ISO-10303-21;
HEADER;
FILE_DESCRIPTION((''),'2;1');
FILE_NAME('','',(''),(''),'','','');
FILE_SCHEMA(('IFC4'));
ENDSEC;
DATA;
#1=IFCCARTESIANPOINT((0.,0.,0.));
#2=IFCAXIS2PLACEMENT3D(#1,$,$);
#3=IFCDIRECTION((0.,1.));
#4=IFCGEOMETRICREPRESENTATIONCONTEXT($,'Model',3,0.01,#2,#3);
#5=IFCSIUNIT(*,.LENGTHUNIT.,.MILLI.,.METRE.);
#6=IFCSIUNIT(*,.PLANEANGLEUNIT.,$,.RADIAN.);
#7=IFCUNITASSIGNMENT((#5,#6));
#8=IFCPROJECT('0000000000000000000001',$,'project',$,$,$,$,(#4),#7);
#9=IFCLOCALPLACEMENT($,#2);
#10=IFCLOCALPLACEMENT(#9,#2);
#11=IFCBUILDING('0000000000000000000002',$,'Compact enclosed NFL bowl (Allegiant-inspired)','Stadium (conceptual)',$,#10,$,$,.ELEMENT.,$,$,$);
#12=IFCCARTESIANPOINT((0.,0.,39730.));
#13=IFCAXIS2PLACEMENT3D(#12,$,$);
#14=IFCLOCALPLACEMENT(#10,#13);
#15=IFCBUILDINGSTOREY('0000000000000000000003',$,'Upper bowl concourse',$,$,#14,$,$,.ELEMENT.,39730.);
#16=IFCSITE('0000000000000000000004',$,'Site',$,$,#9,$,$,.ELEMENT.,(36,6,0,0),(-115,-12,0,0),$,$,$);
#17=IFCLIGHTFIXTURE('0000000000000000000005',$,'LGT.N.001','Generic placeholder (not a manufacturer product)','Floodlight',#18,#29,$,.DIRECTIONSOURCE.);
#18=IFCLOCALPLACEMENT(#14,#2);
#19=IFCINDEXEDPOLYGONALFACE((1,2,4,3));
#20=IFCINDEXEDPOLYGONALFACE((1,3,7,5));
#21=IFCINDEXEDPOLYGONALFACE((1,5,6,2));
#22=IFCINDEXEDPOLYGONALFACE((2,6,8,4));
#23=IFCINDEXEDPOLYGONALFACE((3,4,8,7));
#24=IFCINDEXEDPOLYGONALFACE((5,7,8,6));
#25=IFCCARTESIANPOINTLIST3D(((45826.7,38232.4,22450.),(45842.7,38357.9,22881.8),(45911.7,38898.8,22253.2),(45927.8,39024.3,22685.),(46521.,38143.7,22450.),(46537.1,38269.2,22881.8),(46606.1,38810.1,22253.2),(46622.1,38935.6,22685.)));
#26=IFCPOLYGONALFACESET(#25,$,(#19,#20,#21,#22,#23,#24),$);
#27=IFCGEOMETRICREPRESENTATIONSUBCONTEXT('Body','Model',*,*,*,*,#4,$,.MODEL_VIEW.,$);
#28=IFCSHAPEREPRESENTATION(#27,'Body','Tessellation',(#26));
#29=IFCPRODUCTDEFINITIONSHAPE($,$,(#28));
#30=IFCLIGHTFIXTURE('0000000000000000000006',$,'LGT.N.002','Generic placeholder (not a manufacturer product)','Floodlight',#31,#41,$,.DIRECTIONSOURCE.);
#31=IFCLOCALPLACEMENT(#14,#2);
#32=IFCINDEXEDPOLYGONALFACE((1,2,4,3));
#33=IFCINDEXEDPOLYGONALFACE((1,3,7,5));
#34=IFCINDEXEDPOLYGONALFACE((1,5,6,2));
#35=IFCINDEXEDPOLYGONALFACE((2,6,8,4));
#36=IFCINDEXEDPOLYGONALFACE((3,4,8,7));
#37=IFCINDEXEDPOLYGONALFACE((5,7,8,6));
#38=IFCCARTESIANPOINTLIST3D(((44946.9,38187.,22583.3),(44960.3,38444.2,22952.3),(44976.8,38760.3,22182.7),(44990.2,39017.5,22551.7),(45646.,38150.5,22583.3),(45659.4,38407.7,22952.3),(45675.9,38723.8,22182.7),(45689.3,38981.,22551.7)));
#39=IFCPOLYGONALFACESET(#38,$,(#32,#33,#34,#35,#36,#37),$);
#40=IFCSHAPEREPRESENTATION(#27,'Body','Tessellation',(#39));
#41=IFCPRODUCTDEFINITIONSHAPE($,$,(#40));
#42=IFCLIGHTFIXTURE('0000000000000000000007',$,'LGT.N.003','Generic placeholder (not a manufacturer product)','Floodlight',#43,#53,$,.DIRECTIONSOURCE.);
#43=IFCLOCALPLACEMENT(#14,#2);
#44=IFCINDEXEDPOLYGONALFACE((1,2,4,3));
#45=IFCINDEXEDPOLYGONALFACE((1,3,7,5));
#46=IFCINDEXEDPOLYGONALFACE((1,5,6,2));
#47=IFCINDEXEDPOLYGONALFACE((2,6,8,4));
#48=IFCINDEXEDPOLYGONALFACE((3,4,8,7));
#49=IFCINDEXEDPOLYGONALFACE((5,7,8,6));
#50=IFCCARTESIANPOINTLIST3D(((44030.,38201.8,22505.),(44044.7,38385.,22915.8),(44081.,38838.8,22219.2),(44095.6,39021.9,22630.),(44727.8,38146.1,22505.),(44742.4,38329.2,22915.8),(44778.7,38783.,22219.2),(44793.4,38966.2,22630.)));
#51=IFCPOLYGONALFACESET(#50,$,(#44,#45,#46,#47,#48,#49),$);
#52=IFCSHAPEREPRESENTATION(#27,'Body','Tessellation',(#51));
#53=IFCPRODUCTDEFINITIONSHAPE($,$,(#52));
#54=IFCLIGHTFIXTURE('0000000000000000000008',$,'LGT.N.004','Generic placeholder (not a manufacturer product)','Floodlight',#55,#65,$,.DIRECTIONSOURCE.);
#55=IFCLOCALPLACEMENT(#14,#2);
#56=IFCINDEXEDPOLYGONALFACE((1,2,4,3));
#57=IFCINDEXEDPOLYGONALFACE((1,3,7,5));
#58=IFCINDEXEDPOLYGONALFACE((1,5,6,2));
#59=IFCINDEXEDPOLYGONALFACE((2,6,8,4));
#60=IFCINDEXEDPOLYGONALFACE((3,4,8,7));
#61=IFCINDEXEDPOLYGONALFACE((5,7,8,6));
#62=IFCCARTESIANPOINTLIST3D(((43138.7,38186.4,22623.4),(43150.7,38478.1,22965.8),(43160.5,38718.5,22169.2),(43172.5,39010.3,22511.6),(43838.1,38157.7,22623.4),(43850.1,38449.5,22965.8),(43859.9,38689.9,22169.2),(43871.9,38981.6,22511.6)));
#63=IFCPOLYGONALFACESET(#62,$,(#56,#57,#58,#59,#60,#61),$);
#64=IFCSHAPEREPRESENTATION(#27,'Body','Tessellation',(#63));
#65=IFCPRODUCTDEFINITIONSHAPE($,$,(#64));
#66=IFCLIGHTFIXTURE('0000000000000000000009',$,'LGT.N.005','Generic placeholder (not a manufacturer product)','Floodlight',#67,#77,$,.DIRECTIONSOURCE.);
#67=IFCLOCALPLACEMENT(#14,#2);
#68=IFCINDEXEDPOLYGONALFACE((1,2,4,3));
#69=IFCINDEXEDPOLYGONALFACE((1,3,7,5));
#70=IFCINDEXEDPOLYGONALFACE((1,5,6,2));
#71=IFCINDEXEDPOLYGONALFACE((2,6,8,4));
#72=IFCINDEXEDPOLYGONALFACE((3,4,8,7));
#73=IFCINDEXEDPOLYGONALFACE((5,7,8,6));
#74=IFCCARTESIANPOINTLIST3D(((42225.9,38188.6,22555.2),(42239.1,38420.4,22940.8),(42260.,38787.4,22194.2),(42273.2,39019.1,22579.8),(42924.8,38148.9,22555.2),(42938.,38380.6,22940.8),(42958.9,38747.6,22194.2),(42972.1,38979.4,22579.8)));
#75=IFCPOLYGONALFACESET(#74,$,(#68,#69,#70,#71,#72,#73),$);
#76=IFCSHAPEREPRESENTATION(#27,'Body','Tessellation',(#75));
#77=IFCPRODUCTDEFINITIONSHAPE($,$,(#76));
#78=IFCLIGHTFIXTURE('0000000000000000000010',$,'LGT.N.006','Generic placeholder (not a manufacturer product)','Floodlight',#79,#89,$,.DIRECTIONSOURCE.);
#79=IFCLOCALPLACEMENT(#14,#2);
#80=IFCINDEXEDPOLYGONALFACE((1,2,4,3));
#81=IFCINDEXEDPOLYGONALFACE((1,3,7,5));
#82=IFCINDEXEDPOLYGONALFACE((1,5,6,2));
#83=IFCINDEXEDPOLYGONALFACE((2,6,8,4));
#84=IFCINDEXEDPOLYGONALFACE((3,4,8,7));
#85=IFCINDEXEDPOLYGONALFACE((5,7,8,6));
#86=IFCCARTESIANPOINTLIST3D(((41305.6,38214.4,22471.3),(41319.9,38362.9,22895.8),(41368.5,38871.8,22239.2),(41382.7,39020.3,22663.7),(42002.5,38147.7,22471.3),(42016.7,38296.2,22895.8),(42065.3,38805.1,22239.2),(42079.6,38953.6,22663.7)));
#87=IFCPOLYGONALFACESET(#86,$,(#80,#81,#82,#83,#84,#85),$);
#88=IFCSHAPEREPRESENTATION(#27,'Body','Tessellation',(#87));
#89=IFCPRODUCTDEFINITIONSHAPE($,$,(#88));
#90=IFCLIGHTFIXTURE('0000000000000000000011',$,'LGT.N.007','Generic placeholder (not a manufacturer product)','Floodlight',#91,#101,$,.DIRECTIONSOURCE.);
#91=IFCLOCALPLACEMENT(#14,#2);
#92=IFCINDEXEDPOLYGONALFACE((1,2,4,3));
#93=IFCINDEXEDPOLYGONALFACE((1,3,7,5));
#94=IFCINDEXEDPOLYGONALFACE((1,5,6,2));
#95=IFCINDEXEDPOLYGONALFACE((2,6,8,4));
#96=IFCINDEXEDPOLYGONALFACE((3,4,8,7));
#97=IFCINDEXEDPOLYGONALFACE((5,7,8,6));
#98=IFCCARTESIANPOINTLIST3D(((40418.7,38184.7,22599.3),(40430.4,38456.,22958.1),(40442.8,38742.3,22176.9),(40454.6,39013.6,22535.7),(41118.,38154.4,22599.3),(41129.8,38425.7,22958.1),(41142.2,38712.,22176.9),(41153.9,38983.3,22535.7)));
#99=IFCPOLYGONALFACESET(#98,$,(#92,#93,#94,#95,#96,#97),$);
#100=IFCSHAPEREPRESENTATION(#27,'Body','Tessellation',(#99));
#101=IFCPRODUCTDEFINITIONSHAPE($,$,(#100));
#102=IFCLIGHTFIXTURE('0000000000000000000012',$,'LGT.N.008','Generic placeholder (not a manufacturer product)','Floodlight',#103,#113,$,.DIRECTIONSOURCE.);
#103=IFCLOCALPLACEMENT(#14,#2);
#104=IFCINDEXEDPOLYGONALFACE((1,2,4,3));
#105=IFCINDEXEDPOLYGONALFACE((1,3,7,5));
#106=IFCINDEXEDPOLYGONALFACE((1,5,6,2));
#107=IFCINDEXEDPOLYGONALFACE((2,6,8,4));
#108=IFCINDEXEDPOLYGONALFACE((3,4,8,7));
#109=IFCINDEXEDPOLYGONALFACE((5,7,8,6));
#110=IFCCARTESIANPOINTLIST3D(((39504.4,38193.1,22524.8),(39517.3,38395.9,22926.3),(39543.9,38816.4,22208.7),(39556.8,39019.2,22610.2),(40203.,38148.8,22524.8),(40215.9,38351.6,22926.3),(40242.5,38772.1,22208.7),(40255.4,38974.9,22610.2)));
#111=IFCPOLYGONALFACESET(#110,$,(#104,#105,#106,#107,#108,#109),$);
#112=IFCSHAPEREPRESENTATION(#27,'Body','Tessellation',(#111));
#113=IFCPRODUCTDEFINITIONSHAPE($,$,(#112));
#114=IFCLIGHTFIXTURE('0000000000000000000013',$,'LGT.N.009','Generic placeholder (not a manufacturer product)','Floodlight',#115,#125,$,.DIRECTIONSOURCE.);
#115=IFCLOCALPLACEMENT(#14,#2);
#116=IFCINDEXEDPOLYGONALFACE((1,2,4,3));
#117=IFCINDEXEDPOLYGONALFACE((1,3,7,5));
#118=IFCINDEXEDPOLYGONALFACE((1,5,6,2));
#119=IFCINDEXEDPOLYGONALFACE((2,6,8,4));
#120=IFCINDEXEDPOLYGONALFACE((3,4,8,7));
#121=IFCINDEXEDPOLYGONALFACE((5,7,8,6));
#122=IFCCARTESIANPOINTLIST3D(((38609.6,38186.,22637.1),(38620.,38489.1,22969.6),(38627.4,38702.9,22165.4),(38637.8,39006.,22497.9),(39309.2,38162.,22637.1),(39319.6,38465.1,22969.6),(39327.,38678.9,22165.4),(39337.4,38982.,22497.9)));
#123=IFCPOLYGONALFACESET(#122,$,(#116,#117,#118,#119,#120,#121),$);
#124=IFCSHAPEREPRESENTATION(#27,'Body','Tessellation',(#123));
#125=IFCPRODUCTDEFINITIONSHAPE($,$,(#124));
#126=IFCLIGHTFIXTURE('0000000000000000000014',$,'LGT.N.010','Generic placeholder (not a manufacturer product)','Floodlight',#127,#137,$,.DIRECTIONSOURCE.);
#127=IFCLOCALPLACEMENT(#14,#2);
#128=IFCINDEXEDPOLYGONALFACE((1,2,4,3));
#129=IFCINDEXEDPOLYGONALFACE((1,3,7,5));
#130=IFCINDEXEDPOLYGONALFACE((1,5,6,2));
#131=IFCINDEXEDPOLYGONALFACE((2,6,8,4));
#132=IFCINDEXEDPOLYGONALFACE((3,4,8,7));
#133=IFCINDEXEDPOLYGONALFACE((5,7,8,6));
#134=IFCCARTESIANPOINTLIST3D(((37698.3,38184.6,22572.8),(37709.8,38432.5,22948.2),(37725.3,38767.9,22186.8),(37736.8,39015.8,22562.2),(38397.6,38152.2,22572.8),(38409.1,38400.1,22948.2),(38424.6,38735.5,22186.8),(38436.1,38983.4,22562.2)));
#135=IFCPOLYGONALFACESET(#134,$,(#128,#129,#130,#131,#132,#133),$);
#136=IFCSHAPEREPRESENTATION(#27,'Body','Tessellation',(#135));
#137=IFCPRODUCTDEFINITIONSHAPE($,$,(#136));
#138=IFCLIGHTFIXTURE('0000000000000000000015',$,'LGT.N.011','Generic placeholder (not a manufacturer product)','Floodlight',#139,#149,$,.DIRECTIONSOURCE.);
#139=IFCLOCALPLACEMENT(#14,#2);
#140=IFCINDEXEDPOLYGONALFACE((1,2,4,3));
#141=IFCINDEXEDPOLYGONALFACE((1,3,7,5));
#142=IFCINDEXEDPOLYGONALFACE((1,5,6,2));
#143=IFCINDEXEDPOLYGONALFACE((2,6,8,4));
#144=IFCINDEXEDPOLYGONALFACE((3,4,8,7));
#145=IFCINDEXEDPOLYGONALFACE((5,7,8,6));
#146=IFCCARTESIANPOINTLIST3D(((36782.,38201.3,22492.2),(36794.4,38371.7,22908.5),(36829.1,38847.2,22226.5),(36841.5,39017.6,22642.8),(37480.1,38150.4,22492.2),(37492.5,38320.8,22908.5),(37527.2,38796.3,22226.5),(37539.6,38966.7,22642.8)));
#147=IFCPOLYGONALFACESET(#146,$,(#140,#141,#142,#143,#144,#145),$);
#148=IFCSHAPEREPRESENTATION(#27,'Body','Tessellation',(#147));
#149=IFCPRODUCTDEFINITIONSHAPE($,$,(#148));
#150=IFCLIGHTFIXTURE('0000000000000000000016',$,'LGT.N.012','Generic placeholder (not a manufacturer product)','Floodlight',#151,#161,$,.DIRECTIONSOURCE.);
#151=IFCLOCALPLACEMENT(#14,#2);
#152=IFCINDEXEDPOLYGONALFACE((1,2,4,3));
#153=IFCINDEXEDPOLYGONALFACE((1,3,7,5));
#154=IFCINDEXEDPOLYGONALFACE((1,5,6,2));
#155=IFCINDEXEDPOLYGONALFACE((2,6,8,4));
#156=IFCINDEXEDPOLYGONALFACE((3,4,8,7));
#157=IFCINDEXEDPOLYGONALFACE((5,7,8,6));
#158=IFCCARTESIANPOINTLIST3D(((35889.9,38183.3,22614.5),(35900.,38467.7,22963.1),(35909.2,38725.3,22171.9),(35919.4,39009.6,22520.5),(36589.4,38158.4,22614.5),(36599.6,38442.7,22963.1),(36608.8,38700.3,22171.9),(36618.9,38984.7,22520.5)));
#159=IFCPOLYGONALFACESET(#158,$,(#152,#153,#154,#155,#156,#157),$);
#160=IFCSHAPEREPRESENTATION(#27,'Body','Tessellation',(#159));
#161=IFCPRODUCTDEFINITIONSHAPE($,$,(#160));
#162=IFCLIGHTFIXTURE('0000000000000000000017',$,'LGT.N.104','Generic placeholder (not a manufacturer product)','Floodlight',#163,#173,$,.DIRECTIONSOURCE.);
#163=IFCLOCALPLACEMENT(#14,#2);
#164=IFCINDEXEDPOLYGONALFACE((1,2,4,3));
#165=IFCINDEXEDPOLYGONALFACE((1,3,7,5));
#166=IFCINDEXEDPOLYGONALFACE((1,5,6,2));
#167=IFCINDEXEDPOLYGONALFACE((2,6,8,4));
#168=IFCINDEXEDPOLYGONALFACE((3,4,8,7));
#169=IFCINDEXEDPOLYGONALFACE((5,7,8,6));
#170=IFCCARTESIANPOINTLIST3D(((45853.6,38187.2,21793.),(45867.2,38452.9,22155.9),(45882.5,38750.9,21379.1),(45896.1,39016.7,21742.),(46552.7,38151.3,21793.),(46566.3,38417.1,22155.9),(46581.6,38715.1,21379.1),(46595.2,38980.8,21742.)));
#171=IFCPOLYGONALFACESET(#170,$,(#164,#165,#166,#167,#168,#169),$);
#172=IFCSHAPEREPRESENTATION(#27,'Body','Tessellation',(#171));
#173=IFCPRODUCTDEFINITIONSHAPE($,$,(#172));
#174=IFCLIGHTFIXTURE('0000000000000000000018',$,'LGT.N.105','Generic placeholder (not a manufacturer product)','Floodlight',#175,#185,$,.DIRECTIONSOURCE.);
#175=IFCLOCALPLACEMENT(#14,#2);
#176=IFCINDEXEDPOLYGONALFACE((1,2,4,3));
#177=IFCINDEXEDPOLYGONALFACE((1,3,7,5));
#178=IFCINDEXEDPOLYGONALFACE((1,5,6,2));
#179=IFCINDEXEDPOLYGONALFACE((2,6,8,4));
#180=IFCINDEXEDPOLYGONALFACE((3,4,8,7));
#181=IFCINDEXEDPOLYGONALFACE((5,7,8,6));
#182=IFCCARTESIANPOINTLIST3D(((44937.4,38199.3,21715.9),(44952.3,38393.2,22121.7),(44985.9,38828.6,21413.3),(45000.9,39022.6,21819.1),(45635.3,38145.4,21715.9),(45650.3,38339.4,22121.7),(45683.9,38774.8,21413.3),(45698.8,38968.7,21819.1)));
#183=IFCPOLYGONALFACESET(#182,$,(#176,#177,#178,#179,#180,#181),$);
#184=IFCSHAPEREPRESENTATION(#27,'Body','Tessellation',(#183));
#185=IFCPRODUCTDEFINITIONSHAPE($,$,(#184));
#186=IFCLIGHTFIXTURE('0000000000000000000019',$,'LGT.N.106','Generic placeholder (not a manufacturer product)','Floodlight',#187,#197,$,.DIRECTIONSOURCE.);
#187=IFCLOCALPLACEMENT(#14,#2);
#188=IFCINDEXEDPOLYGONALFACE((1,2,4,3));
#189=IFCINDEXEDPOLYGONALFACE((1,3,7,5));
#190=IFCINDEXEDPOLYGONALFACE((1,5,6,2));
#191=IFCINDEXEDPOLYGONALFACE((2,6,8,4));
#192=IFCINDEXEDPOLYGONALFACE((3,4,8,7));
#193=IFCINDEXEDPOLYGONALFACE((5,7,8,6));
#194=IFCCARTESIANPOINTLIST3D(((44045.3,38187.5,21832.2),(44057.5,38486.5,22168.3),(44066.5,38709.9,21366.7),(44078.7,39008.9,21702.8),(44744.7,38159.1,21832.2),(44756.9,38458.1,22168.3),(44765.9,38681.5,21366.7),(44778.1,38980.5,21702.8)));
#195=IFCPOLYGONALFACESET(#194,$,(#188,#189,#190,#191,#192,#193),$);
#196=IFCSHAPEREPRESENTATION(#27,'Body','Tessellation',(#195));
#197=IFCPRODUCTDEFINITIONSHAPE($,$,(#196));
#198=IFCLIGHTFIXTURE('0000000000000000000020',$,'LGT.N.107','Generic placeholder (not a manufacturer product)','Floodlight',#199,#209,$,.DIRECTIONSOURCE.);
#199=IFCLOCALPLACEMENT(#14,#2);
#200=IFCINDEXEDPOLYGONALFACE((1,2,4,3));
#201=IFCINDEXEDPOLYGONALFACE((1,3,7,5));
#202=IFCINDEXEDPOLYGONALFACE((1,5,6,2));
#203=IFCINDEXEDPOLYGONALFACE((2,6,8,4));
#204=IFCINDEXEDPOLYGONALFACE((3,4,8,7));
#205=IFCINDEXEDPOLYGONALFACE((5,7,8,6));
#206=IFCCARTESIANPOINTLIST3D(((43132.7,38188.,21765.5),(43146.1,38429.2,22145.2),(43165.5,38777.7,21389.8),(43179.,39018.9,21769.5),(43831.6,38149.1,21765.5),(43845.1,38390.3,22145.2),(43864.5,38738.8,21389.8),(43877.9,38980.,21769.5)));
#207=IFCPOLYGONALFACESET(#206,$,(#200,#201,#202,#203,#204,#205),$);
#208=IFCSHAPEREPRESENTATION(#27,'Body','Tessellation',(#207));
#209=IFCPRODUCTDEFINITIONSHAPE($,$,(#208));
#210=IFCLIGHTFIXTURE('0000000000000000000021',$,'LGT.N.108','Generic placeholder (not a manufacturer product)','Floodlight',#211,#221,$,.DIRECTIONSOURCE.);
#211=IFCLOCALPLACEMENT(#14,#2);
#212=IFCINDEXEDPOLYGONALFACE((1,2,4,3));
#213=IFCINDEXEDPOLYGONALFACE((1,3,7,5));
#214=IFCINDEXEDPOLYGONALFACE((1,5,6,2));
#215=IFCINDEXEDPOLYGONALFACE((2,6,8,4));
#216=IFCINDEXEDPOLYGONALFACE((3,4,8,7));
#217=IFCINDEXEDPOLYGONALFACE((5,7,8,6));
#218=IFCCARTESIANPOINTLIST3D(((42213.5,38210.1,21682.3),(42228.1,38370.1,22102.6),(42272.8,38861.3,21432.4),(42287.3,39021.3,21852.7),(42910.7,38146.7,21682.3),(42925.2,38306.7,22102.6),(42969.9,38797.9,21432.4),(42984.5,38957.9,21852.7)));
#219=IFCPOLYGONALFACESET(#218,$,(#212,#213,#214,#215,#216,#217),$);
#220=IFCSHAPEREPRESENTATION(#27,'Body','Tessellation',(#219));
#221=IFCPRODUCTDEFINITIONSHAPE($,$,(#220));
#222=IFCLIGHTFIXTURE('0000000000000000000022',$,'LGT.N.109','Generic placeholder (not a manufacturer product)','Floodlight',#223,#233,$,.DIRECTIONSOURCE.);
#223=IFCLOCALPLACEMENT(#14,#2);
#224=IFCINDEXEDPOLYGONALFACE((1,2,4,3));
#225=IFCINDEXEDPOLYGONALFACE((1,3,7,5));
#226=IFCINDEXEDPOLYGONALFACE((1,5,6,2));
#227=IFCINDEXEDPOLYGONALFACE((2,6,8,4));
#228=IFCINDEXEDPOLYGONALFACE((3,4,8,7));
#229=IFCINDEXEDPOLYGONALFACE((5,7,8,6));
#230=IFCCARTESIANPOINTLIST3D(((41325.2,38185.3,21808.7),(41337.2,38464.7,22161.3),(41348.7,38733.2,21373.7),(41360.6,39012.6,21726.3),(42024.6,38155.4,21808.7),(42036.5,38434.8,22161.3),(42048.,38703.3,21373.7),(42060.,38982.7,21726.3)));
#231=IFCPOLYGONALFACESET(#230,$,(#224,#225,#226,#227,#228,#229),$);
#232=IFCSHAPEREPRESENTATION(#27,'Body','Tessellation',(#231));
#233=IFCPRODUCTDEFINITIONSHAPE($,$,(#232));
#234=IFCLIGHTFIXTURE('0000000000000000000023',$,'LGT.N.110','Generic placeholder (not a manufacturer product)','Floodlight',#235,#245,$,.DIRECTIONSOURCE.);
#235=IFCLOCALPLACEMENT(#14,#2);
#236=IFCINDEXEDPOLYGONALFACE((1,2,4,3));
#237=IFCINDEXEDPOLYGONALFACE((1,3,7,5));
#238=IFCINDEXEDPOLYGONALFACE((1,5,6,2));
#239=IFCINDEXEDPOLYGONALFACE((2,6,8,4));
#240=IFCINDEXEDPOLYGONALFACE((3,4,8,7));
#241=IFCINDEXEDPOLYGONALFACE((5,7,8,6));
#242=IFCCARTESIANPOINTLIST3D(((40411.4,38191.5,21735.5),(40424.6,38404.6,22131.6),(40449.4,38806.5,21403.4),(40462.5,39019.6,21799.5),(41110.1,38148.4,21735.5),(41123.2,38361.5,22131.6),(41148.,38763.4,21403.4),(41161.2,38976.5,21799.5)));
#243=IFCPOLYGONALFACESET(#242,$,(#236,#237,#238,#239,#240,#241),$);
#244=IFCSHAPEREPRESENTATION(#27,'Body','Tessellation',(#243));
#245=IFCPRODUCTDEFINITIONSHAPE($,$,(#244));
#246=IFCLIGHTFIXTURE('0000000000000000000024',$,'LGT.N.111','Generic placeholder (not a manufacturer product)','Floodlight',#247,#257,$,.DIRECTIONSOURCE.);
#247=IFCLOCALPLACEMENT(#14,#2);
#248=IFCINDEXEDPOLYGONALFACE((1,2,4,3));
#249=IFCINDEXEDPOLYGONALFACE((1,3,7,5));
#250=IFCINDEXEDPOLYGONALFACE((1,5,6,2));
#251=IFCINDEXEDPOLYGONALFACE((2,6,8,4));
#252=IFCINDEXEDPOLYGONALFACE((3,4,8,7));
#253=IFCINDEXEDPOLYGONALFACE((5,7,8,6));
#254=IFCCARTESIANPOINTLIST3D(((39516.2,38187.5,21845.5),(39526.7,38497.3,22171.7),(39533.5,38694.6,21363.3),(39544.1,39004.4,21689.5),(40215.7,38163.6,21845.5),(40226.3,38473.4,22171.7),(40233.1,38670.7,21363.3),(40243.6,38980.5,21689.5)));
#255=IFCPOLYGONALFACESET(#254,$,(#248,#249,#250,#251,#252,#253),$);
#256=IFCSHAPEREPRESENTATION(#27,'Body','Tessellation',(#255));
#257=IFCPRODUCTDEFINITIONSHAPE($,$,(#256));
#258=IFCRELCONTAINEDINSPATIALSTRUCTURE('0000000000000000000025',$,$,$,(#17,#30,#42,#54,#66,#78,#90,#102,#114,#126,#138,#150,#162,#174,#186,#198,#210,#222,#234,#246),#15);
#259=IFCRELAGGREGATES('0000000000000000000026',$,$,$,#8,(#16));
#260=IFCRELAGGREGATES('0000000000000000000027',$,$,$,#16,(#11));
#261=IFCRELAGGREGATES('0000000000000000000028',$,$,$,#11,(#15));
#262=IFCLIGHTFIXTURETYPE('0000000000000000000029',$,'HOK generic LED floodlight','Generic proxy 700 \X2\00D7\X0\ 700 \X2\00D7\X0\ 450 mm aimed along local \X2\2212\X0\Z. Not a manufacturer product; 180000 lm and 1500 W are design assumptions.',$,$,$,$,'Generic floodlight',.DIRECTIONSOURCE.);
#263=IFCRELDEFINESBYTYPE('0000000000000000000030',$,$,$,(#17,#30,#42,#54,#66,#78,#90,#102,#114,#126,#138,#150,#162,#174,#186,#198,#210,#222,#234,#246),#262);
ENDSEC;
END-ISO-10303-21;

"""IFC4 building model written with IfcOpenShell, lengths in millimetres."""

from ifc_helpers import new_model, si_unit, direction, frame, origin, place, context, subcontext, project, spatial, rectangle, extrude, source, transform, mapped, type_object, type_shapes, element, save


model = new_model("IFC4")

# Units and contexts
model_context = context("Model", 3, precision=0.01, world=origin(), true_north=direction((0.0, 1.0)))
body_context = subcontext(model_context, "Body", "Model", "MODEL_VIEW")
ifc_project = project(units=[si_unit("LENGTHUNIT", "METRE", prefix="MILLI"), si_unit("PLANEANGLEUNIT", "RADIAN")], contexts=[model_context])

# Site, building, storey
site_placement = place(None, origin())
site = spatial("IfcSite", under=ifc_project, at=site_placement, Name="Site", CompositionType="ELEMENT", RefLatitude=(36, 6, 0, 0), RefLongitude=(-115, -12, 0, 0))
building_placement = place(site_placement, origin())
building = spatial("IfcBuilding", under=site, at=building_placement, Name="Compact enclosed NFL bowl (Allegiant-inspired)", Description="Stadium (conceptual)", CompositionType="ELEMENT")
storey_placement = place(building_placement, frame((0.0, 0.0, 39730.0)))
storey = spatial("IfcBuildingStorey", under=building, at=storey_placement, Name="Upper bowl concourse", CompositionType="ELEMENT", Elevation=39730.0)

# Light fixtures
light_fixture_type = type_object("IfcLightFixtureType", Name="HOK generic LED floodlight", Description="Generic proxy 700 × 700 × 450 mm aimed along local −Z. Not a manufacturer product; 180000 lm and 1500 W are design assumptions.", ElementType="Generic floodlight", PredefinedType="DIRECTIONSOURCE")
shared_shape = source(origin(), body_context, "Body", "SweptSolid", [
    extrude(rectangle(XDim=700.0, YDim=700.0), frame((0.0, 0.0, -225.0)), (0.0, 0.0, 1.0), 450.0),
])
type_shapes(light_fixture_type, [shared_shape])
for number, where, z_axis, x_axis, name in (
    (1, (46224.4, 38584.0, 22567.5), (0.035604, 0.278848, 0.959675), (-0.991947, 0.126653, 0.0), "LGT.N.001"),
    (2, (45318.1, 38584.0, 22567.5), (0.029827, 0.571537, 0.820034), (-0.998641, 0.052116, 0.0), "LGT.N.002"),
    (3, (44411.7, 38584.0, 22567.5), (0.032539, 0.406954, 0.912869), (-0.996819, 0.079703, 0.0), "LGT.N.003"),
    (4, (43505.3, 38584.0, 22567.5), (0.026567, 0.64839, 0.760844), (-0.999162, 0.040939, 0.0), "LGT.N.004"),
    (5, (42599.0, 38584.0, 22567.5), (0.029292, 0.514923, 0.856736), (-0.998386, 0.056794, 0.0), "LGT.N.005"),
    (6, (41692.6, 38584.0, 22567.5), (0.03157, 0.330066, 0.94343), (-0.995457, 0.095212, 0.0), "LGT.N.006"),
    (7, (40786.3, 38584.0, 22567.5), (0.026101, 0.602985, 0.797325), (-0.999064, 0.043245, 0.0), "LGT.N.007"),
    (8, (39879.9, 38584.0, 22567.5), (0.028558, 0.45066, 0.892239), (-0.997998, 0.063243, 0.0), "LGT.N.008"),
    (9, (38973.5, 38584.0, 22567.5), (0.023112, 0.673464, 0.738859), (-0.999412, 0.034297, 0.0), "LGT.N.009"),
    (10, (38067.2, 38584.0, 22567.5), (0.025488, 0.55085, 0.834215), (-0.998931, 0.04622, 0.0), "LGT.N.010"),
    (11, (37160.8, 38584.0, 22567.5), (0.027594, 0.378536, 0.925175), (-0.997354, 0.072703, 0.0), "LGT.N.011"),
    (12, (36254.4, 38584.0, 22567.5), (0.022544, 0.631856, 0.774758), (-0.999364, 0.035656, 0.0), "LGT.N.012"),
    (13, (46224.4, 38584.0, 21767.5), (0.030307, 0.590562, 0.806423), (-0.998686, 0.051252, 0.0), "LGT.N.104"),
    (14, (45318.1, 38584.0, 21767.5), (0.033226, 0.430942, 0.901768), (-0.997041, 0.076873, 0.0), "LGT.N.105"),
    (15, (44411.7, 38584.0, 21767.5), (0.026969, 0.664408, 0.746883), (-0.999177, 0.040557, 0.0), "LGT.N.106"),
    (16, (43505.3, 38584.0, 21767.5), (0.029845, 0.535899, 0.843754), (-0.998453, 0.055605, 0.0), "LGT.N.107"),
    (17, (42599.0, 38584.0, 21767.5), (0.032352, 0.355602, 0.934077), (-0.995887, 0.090603, 0.0), "LGT.N.108"),
    (18, (41692.6, 38584.0, 21767.5), (0.026559, 0.620831, 0.783494), (-0.999086, 0.04274, 0.0), "LGT.N.109"),
    (19, (40786.3, 38584.0, 21767.5), (0.029191, 0.473549, 0.880284), (-0.998105, 0.061526, 0.0), "LGT.N.110"),
    (20, (39879.9, 38584.0, 21767.5), (0.023505, 0.688422, 0.72493), (-0.999418, 0.034124, 0.0), "LGT.N.111"),
):
    element("IfcLightFixture", number, at=place(storey_placement, frame(where, z_axis=z_axis, x_axis=x_axis)), inside=storey, type_object=light_fixture_type, Name=name, Description="Generic placeholder (not a manufacturer product)", ObjectType="Floodlight", PredefinedType="DIRECTIONSOURCE", context=body_context, shape_type="MappedRepresentation", body=[
        mapped(shared_shape, transform((0.0, 0.0, 0.0))),
    ])

save(model, "model.ifc")
